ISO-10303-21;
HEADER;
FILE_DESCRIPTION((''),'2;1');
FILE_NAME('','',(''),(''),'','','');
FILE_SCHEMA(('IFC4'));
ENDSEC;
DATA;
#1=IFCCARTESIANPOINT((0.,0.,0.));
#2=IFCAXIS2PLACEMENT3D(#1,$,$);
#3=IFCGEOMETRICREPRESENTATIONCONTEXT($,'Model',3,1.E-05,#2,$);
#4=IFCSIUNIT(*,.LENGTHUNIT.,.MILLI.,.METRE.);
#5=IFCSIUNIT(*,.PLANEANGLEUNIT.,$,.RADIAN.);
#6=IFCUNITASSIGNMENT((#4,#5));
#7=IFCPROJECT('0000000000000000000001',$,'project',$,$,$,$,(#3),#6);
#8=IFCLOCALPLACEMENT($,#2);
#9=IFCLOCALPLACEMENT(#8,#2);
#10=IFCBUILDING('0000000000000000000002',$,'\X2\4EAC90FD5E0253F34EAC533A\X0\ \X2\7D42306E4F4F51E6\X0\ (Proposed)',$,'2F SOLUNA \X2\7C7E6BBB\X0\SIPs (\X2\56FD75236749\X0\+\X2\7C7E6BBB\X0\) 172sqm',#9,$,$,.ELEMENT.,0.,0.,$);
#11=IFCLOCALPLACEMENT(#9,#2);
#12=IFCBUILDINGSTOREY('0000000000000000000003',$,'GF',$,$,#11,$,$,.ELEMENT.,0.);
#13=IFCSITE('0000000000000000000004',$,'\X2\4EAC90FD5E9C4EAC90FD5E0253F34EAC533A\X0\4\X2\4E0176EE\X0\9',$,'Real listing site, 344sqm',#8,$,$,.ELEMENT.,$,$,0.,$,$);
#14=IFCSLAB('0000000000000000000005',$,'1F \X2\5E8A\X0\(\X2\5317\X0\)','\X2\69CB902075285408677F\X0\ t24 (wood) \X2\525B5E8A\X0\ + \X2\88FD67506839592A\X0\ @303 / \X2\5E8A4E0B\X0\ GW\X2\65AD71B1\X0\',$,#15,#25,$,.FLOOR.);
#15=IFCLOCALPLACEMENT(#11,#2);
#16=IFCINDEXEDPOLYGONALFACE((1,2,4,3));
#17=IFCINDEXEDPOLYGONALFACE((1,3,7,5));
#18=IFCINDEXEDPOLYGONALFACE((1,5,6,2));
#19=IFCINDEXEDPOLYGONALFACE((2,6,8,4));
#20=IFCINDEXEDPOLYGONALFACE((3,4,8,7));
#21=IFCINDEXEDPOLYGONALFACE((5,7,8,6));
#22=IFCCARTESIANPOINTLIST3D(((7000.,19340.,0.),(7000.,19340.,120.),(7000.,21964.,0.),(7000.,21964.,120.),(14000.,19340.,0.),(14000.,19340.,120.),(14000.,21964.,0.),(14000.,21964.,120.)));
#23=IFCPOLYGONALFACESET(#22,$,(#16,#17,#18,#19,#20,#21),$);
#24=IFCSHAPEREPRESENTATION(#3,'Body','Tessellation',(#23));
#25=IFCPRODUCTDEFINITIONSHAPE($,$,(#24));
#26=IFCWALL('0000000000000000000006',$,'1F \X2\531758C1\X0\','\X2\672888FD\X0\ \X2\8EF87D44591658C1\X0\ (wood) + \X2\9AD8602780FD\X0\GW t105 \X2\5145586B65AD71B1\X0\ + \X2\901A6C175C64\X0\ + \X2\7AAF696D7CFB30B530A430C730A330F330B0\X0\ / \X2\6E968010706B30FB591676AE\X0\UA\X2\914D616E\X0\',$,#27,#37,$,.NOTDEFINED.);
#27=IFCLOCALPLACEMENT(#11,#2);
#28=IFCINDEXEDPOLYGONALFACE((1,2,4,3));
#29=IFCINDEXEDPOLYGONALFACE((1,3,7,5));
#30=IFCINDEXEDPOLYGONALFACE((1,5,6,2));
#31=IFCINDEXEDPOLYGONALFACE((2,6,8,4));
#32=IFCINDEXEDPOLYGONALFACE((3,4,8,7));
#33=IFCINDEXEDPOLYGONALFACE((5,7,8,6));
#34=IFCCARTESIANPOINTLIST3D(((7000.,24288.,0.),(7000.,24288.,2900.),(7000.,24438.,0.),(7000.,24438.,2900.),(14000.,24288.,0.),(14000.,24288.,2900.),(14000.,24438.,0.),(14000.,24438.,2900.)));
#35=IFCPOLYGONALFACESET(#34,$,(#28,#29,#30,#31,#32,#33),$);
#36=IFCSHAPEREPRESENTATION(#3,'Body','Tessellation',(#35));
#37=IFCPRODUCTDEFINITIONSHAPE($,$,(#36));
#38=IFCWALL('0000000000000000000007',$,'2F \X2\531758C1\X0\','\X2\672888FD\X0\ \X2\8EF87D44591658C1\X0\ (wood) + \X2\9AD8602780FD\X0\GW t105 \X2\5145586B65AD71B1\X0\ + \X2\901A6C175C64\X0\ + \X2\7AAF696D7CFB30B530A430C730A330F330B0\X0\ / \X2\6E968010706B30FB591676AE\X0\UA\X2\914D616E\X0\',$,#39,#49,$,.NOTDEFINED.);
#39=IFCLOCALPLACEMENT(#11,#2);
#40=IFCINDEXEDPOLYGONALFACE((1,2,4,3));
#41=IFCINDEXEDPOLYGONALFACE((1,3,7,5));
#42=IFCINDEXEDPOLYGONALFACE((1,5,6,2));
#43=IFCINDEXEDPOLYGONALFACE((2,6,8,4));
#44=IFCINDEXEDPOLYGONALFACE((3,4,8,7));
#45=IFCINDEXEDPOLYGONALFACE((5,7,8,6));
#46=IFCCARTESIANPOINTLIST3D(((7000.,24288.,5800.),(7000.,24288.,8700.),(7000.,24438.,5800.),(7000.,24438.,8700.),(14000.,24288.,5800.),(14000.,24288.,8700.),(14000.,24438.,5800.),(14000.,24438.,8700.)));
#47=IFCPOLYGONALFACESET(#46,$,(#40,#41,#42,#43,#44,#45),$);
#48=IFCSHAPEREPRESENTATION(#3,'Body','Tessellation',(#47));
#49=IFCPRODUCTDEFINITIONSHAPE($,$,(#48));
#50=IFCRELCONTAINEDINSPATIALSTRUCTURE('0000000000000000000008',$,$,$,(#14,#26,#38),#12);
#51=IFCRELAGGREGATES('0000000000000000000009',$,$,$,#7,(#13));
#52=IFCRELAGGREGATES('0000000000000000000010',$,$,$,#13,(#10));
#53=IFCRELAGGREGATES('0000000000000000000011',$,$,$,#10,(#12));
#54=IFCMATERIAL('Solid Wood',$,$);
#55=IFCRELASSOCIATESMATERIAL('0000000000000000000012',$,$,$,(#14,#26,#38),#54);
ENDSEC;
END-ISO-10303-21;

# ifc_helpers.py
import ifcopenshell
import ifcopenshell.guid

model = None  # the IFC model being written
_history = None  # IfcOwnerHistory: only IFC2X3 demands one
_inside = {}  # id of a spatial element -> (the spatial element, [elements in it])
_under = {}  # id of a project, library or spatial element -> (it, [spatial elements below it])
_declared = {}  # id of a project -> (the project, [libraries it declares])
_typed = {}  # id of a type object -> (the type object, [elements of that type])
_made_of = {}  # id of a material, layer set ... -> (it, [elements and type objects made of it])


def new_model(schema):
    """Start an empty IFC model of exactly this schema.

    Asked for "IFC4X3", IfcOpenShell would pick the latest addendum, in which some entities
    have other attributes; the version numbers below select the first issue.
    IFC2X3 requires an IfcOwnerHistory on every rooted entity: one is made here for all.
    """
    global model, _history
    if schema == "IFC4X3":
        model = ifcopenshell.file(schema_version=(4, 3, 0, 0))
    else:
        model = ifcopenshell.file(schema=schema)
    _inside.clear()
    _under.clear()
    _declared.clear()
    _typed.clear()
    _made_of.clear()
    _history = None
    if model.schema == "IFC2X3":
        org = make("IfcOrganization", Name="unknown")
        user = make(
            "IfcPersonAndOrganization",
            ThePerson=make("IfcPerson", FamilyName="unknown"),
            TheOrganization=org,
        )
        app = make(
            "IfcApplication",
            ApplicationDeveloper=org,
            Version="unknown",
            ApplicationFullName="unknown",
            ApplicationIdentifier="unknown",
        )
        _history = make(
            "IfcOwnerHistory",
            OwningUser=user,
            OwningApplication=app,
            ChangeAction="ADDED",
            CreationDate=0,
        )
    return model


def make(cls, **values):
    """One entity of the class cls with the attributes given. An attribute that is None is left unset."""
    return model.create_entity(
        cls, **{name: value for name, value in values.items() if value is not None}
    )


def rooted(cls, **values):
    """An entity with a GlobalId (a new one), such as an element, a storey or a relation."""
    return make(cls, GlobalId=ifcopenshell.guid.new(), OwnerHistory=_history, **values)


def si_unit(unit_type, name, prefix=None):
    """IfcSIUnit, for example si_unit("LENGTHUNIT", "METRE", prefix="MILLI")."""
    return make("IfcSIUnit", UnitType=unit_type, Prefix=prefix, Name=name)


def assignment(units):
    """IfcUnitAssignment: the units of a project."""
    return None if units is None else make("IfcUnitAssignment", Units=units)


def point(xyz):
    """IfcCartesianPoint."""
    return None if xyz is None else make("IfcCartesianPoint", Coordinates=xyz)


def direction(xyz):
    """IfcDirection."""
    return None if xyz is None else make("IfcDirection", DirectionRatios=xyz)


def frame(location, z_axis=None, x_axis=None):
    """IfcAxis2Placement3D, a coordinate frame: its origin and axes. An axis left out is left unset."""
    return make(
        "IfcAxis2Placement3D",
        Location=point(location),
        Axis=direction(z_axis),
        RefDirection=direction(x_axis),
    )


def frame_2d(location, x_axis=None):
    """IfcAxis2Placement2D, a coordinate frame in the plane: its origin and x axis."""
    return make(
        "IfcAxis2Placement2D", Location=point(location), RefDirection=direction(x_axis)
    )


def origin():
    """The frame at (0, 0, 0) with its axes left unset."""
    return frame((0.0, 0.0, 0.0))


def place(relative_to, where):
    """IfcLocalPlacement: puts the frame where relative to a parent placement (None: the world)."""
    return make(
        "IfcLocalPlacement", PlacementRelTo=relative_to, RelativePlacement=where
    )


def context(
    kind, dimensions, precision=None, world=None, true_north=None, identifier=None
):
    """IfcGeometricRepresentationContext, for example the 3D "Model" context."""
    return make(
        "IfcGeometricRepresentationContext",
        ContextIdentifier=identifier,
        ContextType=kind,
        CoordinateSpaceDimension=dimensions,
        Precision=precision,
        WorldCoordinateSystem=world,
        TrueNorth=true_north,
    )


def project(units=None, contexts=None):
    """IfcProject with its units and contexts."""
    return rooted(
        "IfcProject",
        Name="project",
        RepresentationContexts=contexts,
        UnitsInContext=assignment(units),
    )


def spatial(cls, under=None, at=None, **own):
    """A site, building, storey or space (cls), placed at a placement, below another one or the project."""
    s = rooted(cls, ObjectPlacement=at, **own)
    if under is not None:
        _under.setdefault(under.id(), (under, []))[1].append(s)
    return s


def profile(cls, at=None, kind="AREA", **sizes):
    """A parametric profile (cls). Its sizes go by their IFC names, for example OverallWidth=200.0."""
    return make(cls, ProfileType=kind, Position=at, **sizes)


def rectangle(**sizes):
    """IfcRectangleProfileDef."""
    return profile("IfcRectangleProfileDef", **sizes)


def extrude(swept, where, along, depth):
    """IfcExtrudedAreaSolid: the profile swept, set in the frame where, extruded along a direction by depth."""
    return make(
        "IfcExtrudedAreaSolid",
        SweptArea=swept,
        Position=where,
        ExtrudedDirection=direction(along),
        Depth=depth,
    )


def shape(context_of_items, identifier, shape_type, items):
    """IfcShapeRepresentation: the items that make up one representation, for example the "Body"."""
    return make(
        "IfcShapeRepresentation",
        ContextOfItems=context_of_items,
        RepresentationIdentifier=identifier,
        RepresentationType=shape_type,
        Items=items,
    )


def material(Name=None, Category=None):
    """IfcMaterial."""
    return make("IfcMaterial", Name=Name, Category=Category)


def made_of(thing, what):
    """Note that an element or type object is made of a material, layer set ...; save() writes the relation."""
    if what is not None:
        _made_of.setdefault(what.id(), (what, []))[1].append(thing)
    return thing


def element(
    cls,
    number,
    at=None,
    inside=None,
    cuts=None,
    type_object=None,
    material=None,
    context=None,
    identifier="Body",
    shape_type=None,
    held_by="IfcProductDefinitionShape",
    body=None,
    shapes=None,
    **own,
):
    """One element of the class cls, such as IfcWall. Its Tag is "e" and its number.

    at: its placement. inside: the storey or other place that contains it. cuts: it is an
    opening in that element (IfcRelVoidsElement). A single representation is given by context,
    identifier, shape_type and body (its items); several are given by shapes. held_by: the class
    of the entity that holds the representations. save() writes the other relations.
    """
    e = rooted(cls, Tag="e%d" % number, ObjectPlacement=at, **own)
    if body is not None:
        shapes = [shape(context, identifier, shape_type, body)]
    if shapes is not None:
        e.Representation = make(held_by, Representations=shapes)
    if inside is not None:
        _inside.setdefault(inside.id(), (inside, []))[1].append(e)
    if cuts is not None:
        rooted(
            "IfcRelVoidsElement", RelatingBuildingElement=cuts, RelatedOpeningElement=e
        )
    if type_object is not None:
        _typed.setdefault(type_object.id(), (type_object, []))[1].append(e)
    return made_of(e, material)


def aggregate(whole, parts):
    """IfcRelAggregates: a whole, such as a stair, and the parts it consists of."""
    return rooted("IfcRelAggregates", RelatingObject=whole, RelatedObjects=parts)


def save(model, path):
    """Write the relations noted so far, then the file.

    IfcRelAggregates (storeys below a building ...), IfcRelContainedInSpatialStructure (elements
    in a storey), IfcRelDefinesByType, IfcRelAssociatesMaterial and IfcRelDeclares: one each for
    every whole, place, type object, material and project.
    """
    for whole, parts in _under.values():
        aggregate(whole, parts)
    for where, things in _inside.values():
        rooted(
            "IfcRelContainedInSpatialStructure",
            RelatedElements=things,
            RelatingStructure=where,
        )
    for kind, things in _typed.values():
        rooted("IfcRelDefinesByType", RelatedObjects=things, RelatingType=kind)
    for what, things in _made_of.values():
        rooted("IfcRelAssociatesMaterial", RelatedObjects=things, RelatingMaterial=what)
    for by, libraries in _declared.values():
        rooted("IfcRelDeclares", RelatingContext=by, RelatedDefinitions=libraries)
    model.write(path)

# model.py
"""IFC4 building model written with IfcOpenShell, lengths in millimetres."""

from ifc_helpers import new_model, si_unit, frame, frame_2d, origin, place, context, project, spatial, rectangle, extrude, material, element, save


model = new_model("IFC4")

# Units and contexts
model_context = context("Model", 3, precision=1e-05, world=origin())
ifc_project = project(units=[si_unit("LENGTHUNIT", "METRE", prefix="MILLI"), si_unit("PLANEANGLEUNIT", "RADIAN")], contexts=[model_context])

# Site, building, storey
site_placement = place(None, origin())
site = spatial("IfcSite", under=ifc_project, at=site_placement, Name="京都府京都市右京区4丁目9", ObjectType="Real listing site, 344sqm", CompositionType="ELEMENT", RefElevation=0.0)
building_placement = place(site_placement, origin())
building = spatial("IfcBuilding", under=site, at=building_placement, Name="京都市右京区 終の住処 (Proposed)", ObjectType="2F SOLUNA 籾殻SIPs (国産杉+籾殻) 172sqm", CompositionType="ELEMENT", ElevationOfRefHeight=0.0, ElevationOfTerrain=0.0)
storey_placement = place(building_placement, origin())
storey = spatial("IfcBuildingStorey", under=building, at=storey_placement, Name="GF", CompositionType="ELEMENT", Elevation=0.0)

# Slab
ifc_material_1 = material(Name="Solid Wood")
slab_1_placement = place(storey_placement, frame((3500.0, 9670.0, 0.0)))
element("IfcSlab", 1, at=slab_1_placement, inside=storey, material=ifc_material_1, Name="1F 床(北)", Description="構造用合板 t24 (wood) 剛床 + 製材根太 @303 / 床下 GW断熱", PredefinedType="FLOOR", context=model_context, shape_type="SweptSolid", body=[
    extrude(rectangle(XDim=7000.0, YDim=2624.0, at=frame_2d((3500.0, 1312.0))), frame((3500.0, 9670.0, 0.0)), (0.0, 0.0, 1.0), 120.0),
])

# Wall
wall_1_placement = place(storey_placement, frame((3500.0, 12144.0, 0.0)))
element("IfcWall", 2, at=wall_1_placement, inside=storey, material=ifc_material_1, Name="1F 北壁", Description="木製 軸組外壁 (wood) + 高性能GW t105 充填断熱 + 通気層 + 窯業系サイディング / 準耐火・外皮UA配慮", PredefinedType="NOTDEFINED", context=model_context, shape_type="SweptSolid", body=[
    extrude(rectangle(XDim=7000.0, YDim=150.0, at=frame_2d((3500.0, 75.0))), frame((3500.0, 12144.0, 0.0)), (0.0, 0.0, 1.0), 2900.0),
])

# Wall
wall_2_placement = place(storey_placement, frame((3500.0, 12144.0, 2900.0)))
element("IfcWall", 3, at=wall_2_placement, inside=storey, material=ifc_material_1, Name="2F 北壁", Description="木製 軸組外壁 (wood) + 高性能GW t105 充填断熱 + 通気層 + 窯業系サイディング / 準耐火・外皮UA配慮", PredefinedType="NOTDEFINED", context=model_context, shape_type="SweptSolid", body=[
    extrude(rectangle(XDim=7000.0, YDim=150.0, at=frame_2d((3500.0, 75.0))), frame((3500.0, 12144.0, 2900.0)), (0.0, 0.0, 1.0), 2900.0),
])

save(model, "model.ifc")
